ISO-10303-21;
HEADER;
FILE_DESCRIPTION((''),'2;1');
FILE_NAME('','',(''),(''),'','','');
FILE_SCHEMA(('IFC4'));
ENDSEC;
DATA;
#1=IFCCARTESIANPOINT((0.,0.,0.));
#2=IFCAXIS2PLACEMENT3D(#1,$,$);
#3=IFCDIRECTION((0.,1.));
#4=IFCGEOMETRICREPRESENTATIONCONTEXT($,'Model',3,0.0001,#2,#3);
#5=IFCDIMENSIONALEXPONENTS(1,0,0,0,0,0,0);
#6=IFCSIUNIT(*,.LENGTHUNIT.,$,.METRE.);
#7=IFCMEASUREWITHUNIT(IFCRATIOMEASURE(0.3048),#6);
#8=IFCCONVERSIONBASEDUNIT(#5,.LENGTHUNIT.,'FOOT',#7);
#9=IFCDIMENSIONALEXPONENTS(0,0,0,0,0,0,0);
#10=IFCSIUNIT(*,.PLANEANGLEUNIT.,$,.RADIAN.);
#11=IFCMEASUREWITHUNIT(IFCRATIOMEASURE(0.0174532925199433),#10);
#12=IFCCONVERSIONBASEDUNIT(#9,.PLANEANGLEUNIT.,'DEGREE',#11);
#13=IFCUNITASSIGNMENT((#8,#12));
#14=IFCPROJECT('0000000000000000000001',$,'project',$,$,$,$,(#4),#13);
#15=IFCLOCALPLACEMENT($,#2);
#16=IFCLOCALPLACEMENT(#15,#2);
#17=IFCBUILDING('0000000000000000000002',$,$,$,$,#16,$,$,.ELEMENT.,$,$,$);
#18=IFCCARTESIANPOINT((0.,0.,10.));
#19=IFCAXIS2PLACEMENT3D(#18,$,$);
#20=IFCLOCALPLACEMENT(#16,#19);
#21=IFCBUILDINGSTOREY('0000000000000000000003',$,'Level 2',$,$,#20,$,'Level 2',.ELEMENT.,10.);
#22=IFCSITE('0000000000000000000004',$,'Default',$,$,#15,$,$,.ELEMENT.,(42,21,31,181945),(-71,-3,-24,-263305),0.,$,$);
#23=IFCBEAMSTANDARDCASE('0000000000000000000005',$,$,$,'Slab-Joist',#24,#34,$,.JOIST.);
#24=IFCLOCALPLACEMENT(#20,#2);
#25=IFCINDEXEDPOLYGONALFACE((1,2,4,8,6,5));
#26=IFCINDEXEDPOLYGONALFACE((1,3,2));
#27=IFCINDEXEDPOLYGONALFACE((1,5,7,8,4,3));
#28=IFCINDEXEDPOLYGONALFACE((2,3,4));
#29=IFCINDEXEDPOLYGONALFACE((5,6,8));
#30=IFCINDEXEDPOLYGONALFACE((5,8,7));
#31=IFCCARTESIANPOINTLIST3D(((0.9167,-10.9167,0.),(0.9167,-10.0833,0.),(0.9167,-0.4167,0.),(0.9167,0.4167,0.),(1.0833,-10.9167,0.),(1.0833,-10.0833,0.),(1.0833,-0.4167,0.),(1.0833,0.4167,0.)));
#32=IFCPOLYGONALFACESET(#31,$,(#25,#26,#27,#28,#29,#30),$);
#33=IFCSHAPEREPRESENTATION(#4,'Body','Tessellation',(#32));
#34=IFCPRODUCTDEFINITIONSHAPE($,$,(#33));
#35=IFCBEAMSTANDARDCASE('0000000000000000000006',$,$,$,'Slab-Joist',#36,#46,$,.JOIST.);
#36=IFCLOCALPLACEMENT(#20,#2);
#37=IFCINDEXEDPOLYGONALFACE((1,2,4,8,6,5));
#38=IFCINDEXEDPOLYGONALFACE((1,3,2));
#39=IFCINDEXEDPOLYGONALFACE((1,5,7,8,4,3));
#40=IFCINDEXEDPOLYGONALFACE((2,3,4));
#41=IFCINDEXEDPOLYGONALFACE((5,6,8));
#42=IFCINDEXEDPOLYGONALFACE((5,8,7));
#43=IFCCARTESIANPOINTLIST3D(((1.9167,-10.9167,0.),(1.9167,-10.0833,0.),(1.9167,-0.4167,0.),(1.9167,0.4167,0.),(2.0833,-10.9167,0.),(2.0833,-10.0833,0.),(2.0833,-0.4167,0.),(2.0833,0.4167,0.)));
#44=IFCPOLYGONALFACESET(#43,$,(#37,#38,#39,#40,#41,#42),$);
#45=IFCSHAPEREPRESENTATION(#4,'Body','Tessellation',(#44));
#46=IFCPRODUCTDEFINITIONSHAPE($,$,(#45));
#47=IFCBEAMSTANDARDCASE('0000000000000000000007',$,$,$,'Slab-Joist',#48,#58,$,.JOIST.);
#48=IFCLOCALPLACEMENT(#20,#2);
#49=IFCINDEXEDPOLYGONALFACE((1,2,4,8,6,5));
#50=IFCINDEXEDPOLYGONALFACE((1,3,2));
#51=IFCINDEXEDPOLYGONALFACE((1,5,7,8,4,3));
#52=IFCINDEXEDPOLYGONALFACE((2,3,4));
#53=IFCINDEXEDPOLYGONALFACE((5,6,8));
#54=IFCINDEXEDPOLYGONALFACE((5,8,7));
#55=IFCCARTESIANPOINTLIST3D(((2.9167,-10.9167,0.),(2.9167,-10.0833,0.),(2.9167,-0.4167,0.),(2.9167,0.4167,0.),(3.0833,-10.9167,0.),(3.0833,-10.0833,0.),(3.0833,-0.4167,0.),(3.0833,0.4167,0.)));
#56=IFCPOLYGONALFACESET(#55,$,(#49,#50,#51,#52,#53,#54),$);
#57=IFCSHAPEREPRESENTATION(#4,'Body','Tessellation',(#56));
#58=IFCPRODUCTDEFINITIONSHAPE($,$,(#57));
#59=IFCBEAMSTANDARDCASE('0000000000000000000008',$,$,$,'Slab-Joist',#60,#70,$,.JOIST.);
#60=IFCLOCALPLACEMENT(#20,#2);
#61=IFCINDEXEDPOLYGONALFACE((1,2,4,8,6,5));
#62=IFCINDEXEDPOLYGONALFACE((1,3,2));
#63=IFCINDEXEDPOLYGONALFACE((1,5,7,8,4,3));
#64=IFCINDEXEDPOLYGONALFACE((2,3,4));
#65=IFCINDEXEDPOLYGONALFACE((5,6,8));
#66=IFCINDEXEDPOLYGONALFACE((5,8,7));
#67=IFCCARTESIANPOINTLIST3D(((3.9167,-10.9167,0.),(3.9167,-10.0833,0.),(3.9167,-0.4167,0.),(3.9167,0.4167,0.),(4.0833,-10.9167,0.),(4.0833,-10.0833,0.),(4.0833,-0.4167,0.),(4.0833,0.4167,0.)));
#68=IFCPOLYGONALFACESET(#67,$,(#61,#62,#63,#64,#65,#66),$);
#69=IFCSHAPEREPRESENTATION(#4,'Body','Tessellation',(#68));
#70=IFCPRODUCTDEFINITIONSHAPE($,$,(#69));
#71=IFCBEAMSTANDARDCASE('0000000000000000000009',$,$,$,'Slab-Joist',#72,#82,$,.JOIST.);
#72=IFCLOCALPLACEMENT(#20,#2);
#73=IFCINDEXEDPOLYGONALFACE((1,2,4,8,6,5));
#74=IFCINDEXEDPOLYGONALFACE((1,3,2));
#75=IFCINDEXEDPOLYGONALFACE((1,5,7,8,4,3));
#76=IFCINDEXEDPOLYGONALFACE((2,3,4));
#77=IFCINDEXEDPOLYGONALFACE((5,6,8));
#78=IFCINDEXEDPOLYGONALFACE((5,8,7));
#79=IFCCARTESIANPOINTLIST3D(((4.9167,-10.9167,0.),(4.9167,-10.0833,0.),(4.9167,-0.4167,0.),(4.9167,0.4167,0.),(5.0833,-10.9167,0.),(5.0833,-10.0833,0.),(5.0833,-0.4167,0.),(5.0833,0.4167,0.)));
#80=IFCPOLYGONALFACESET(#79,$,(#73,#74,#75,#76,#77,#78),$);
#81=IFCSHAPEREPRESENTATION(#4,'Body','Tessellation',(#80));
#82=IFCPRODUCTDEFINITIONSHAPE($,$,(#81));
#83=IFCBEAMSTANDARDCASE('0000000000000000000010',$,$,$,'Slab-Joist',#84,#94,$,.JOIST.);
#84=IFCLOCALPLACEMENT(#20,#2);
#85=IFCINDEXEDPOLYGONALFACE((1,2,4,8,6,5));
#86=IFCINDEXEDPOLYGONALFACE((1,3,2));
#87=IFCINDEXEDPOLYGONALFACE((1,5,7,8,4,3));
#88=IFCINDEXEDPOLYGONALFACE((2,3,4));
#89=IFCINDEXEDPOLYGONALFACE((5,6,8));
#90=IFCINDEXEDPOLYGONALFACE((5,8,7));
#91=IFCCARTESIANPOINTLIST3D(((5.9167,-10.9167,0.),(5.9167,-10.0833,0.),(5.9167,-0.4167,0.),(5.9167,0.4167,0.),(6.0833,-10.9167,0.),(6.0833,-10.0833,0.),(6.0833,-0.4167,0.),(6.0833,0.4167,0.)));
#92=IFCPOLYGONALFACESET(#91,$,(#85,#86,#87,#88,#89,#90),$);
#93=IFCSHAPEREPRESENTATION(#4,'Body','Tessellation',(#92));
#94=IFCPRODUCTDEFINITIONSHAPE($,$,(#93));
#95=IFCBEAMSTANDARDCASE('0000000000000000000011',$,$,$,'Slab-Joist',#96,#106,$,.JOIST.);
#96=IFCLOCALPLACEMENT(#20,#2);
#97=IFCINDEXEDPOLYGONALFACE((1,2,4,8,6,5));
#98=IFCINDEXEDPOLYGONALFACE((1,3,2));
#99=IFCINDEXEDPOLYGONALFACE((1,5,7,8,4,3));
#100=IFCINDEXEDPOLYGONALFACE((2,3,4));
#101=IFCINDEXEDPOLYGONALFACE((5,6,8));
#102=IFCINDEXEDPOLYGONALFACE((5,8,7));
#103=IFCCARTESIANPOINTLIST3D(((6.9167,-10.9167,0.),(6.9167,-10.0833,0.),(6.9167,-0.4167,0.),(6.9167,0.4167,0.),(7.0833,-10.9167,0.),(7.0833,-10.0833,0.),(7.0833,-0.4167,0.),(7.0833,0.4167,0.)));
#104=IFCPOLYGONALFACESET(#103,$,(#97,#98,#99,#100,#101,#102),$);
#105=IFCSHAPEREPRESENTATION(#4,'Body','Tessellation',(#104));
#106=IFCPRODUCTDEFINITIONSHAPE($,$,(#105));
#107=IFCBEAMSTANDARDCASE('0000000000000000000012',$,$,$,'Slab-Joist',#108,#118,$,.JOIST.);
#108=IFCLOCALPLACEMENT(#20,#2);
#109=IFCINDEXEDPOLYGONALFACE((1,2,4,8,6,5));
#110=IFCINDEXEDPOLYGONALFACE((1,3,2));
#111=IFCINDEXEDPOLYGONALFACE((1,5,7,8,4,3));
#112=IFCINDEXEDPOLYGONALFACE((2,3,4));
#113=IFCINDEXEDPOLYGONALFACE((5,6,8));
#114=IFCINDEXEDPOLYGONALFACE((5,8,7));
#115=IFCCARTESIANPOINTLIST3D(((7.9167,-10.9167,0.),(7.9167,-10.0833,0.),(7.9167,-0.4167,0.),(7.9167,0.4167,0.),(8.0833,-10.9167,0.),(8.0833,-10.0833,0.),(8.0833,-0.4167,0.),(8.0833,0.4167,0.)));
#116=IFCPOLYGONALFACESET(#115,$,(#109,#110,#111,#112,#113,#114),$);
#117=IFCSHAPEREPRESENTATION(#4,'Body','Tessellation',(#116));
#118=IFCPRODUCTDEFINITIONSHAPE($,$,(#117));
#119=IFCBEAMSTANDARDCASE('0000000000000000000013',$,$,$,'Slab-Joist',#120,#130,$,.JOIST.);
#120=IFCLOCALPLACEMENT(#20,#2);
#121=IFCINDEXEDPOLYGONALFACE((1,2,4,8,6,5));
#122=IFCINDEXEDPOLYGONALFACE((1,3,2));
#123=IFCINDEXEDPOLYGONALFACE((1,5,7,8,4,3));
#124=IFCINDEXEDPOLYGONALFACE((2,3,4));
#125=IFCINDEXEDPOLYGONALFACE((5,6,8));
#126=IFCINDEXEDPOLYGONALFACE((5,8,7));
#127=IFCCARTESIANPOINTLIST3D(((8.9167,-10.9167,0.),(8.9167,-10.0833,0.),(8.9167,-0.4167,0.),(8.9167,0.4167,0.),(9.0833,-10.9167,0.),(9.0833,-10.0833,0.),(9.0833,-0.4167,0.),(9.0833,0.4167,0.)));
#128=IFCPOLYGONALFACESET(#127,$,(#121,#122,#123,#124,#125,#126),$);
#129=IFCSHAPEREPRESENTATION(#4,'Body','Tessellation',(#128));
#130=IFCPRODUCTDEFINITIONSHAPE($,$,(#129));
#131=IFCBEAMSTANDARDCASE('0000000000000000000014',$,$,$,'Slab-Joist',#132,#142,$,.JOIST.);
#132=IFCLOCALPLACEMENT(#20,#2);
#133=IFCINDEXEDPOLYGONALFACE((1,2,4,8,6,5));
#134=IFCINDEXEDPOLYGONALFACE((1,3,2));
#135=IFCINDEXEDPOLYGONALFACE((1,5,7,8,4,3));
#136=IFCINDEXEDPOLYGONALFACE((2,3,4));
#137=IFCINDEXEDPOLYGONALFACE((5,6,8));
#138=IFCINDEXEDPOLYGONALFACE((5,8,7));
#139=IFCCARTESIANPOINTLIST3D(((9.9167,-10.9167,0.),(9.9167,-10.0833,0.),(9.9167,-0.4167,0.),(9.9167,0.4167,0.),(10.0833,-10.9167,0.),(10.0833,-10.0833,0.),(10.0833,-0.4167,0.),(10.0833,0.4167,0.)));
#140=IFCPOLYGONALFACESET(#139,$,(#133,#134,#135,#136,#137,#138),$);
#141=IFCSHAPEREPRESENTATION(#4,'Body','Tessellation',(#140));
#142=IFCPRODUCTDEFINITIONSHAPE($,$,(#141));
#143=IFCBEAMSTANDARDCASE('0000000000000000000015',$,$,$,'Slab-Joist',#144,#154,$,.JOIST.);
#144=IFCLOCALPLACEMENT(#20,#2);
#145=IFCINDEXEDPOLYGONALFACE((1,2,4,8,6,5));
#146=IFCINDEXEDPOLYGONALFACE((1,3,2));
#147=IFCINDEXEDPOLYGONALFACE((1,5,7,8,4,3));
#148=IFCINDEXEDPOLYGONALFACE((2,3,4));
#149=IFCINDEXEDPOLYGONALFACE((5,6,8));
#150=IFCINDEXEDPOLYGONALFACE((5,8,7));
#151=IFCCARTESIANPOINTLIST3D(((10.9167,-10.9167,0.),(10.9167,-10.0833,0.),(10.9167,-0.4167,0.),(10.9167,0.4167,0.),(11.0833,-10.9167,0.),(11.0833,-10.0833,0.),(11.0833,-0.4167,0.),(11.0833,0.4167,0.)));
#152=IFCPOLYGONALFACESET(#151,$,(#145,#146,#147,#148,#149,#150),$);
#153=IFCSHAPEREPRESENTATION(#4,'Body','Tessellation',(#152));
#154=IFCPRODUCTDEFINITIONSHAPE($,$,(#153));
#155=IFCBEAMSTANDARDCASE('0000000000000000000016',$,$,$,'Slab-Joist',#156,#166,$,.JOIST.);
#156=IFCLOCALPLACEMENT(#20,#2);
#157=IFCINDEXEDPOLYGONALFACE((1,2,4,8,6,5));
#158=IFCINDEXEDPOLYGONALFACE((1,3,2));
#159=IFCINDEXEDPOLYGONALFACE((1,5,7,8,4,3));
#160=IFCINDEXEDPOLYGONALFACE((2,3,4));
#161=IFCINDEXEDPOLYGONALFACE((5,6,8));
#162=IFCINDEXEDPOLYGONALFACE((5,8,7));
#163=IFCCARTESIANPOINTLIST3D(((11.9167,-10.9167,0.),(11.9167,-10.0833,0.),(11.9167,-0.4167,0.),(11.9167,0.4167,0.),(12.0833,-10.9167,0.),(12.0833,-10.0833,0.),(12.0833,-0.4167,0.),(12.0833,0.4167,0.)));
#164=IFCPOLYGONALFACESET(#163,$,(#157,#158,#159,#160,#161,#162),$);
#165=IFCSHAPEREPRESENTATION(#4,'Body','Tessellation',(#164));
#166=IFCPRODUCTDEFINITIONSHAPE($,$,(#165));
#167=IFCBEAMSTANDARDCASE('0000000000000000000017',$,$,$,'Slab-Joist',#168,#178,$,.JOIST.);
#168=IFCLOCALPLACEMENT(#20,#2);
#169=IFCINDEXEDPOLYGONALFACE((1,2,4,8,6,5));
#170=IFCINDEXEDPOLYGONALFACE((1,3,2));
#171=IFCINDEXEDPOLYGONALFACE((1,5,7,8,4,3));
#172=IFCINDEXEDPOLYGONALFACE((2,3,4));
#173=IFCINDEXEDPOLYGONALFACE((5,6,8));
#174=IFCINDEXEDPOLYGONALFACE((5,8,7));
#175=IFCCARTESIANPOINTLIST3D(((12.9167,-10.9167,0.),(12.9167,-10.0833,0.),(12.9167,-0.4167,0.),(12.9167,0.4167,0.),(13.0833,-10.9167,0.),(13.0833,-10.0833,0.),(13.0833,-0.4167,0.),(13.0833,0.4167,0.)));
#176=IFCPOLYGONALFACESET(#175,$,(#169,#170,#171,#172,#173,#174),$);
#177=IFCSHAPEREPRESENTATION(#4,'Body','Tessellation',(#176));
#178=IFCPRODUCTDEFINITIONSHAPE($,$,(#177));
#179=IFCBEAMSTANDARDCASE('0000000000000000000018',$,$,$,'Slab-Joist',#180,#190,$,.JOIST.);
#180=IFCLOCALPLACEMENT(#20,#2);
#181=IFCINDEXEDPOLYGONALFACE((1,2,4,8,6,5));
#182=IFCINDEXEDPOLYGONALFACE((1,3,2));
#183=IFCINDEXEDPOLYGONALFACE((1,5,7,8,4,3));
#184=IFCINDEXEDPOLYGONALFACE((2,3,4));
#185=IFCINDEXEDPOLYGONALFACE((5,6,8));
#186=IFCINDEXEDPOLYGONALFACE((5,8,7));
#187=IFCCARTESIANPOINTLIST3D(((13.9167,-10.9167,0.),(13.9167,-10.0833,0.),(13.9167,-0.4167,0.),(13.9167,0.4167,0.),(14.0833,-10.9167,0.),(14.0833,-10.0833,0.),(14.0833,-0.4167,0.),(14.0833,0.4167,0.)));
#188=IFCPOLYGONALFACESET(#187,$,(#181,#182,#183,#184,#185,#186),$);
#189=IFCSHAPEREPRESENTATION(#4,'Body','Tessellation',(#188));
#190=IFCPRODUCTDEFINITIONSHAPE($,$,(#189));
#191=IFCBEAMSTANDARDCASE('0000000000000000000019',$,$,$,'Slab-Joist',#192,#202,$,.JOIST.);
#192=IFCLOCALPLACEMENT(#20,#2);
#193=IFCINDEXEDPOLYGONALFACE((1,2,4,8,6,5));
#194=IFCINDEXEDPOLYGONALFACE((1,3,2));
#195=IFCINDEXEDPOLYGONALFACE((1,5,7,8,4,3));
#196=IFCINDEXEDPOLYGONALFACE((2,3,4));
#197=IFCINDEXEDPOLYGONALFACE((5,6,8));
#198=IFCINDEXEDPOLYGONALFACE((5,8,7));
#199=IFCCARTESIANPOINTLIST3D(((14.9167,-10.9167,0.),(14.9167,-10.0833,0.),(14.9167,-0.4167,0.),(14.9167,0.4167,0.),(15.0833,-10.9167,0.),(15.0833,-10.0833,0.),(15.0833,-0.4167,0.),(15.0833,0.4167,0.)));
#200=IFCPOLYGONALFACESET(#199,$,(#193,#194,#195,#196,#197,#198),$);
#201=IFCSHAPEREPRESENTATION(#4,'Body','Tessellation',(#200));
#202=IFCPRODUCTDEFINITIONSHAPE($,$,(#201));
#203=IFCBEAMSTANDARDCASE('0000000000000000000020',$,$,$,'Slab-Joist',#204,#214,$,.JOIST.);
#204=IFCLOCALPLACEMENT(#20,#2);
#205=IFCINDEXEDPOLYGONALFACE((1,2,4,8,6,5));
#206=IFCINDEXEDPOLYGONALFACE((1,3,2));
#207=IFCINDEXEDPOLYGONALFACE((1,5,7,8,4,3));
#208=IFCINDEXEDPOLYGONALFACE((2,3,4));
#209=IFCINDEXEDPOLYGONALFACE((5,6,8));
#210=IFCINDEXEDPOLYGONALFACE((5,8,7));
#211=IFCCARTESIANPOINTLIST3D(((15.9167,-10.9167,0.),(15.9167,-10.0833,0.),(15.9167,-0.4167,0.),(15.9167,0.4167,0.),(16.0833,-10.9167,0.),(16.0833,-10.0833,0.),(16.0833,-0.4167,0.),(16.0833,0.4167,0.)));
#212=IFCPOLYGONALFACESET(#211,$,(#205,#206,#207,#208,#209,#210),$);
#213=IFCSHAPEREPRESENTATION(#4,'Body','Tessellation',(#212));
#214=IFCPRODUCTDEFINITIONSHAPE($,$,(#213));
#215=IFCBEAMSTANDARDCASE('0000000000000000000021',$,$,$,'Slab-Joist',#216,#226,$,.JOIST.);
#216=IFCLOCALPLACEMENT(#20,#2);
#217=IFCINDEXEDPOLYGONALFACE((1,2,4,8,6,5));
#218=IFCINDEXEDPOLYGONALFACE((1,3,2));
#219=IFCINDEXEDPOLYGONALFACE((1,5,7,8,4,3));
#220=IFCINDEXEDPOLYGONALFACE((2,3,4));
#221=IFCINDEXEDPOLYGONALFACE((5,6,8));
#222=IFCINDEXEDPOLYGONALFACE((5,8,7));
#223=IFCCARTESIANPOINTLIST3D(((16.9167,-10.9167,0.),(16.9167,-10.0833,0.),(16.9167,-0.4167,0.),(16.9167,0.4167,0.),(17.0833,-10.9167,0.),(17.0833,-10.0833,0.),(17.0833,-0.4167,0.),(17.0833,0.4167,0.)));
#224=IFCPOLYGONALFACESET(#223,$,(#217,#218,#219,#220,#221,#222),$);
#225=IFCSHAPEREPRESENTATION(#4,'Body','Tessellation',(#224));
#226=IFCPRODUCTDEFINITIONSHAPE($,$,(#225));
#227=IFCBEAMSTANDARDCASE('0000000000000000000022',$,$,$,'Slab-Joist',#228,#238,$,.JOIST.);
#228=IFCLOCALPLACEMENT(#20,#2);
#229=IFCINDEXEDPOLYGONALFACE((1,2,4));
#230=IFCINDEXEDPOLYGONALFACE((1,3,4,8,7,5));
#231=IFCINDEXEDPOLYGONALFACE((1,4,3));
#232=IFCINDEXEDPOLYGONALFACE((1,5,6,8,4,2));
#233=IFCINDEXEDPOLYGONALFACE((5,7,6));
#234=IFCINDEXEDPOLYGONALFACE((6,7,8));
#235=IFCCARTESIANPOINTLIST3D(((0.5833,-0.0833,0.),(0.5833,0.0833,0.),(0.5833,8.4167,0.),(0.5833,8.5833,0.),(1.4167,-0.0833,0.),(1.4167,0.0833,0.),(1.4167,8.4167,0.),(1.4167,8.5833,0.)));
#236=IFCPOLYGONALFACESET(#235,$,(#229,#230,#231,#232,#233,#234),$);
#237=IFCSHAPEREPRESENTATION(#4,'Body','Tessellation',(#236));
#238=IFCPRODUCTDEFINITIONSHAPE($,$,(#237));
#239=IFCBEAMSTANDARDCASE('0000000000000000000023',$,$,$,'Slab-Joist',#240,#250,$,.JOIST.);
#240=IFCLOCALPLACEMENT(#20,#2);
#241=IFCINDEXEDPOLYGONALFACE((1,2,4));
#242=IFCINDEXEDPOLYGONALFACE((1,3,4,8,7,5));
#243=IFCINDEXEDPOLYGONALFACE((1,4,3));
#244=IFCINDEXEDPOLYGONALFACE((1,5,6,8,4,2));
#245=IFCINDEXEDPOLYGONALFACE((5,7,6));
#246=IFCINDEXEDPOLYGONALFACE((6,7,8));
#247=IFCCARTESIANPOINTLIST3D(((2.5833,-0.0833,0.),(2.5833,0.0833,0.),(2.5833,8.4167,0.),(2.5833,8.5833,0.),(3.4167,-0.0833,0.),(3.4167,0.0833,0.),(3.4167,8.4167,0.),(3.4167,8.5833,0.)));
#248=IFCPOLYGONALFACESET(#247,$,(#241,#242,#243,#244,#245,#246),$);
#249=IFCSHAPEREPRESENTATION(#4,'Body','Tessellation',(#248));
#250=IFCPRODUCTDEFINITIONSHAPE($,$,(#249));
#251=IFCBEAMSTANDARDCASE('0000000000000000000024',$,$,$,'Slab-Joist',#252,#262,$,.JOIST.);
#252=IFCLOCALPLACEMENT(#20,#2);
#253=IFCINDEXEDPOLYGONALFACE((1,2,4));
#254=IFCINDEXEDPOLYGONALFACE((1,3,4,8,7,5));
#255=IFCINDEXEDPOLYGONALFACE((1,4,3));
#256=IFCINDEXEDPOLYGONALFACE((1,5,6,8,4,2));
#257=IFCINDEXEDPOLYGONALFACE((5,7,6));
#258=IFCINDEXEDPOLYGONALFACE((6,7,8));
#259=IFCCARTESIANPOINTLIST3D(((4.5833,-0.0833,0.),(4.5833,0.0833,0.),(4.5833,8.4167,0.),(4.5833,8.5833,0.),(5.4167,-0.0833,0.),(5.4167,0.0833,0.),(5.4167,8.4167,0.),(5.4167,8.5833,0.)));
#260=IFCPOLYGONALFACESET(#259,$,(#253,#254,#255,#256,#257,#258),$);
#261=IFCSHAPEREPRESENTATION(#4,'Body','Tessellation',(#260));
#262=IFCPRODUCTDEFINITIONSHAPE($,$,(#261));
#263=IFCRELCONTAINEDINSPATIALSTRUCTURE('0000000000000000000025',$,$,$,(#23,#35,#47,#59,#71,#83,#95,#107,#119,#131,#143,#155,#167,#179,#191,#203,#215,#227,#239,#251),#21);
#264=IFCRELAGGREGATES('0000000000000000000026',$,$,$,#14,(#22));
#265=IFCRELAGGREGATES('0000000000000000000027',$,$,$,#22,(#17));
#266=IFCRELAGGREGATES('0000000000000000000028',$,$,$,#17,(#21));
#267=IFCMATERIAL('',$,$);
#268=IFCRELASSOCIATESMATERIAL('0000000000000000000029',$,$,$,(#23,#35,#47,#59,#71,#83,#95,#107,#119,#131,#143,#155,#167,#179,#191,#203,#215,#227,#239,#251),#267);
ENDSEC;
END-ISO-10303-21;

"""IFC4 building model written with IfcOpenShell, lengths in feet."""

from ifc_helpers import new_model, entity, si_unit, converted_unit, direction, frame, origin, place, context, project, spatial, rectangle, extrude, material, element, save


model = new_model("IFC4")

# Units and contexts
model_context = context("Model", 3, precision=0.0001, world=origin(), true_north=direction((0.0, 1.0)))
ifc_project = project(units=[converted_unit("LENGTHUNIT", "FOOT", entity("IfcRatioMeasure", 0.3048), si_unit("LENGTHUNIT", "METRE"), dimensions=[1, 0, 0, 0, 0, 0, 0]), converted_unit("PLANEANGLEUNIT", "DEGREE", entity("IfcRatioMeasure", 0.0174532925199433), si_unit("PLANEANGLEUNIT", "RADIAN"), dimensions=[0, 0, 0, 0, 0, 0, 0])], contexts=[model_context])

# Site, building, storey
site_placement = place(None, origin())
site = spatial("IfcSite", under=ifc_project, at=site_placement, Name="Default", CompositionType="ELEMENT", RefLatitude=(42, 21, 31, 181945), RefLongitude=(-71, -3, -24, -263305), RefElevation=0.0)
building_placement = place(site_placement, origin())
building = spatial("IfcBuilding", under=site, at=building_placement, CompositionType="ELEMENT")
storey_placement = place(building_placement, frame((0.0, 0.0, 10.0)))
storey = spatial("IfcBuildingStorey", under=building, at=storey_placement, Name="Level 2", LongName="Level 2", CompositionType="ELEMENT", Elevation=10.0)

# Beams
ifc_material_1 = material(Name="")
for number, where, z_axis, x_axis in (
    (1, (1.0, 0.0, 0.0), (0.0, 0.0, 1.0), (1.0, 0.0, 0.0)),
    (2, (2.0, 0.0, 0.0), (0.0, 0.0, 1.0), (1.0, 0.0, 0.0)),
    (3, (3.0, 0.0, 0.0), (0.0, 0.0, 1.0), (1.0, 0.0, 0.0)),
    (4, (4.0, 0.0, 0.0), (0.0, 0.0, 1.0), (1.0, 0.0, 0.0)),
    (5, (5.0, 0.0, 0.0), (0.0, 0.0, 1.0), (1.0, 0.0, 0.0)),
    (6, (6.0, 0.0, 0.0), (0.0, 0.0, 1.0), (1.0, 0.0, 0.0)),
    (7, (7.0, 0.0, 0.0), (0.0, 0.0, 1.0), (1.0, 0.0, 0.0)),
    (8, (8.0, 0.0, 0.0), (0.0, 0.0, 1.0), (1.0, 0.0, 0.0)),
    (9, (9.0, 0.0, 0.0), (0.0, 0.0, 1.0), (1.0, 0.0, 0.0)),
    (10, (10.0, 0.0, 0.0), (0.0, 0.0, 1.0), (1.0, 0.0, 0.0)),
    (11, (11.0, 0.0, 0.0), (0.0, 0.0, 1.0), (1.0, 0.0, 0.0)),
    (12, (12.0, 0.0, 0.0), (0.0, 0.0, 1.0), (1.0, 0.0, 0.0)),
    (13, (13.0, 0.0, 0.0), (0.0, 0.0, 1.0), (1.0, 0.0, 0.0)),
    (14, (14.0, 0.0, 0.0), (0.0, 0.0, 1.0), (1.0, 0.0, 0.0)),
    (15, (15.0, 0.0, 0.0), (0.0, 0.0, 1.0), (1.0, 0.0, 0.0)),
    (16, (16.0, 0.0, 0.0), (0.0, 0.0, 1.0), (1.0, 0.0, 0.0)),
    (17, (17.0, 0.0, 0.0), (0.0, 0.0, 1.0), (1.0, 0.0, 0.0)),
):
    element("IfcBeamStandardCase", number, at=place(storey_placement, frame(where, z_axis=z_axis, x_axis=x_axis)), inside=storey, material=ifc_material_1, ObjectType="Slab-Joist", PredefinedType="JOIST", context=model_context, shape_type="SweptSolid", body=[
        extrude(rectangle(XDim=0.1667, YDim=0.8333), frame((0.0, 0.0, 0.0), z_axis=(0.0, 0.0, 1.0), x_axis=(-1.0, 0.0, 0.0)), (0.0, 1.0, 0.0), 10.5),
    ])
for number, where, z_axis, x_axis in (
    (18, (1.0, 0.0, 0.0), (0.0, 0.0, 1.0), (1.0, 0.0, 0.0)),
    (19, (3.0, 0.0, 0.0), (0.0, 0.0, 1.0), (1.0, 0.0, 0.0)),
    (20, (5.0, 0.0, 0.0), (0.0, 0.0, 1.0), (1.0, 0.0, 0.0)),
):
    element("IfcBeamStandardCase", number, at=place(storey_placement, frame(where, z_axis=z_axis, x_axis=x_axis)), inside=storey, material=ifc_material_1, ObjectType="Slab-Joist", PredefinedType="JOIST", context=model_context, shape_type="SweptSolid", body=[
        extrude(rectangle(XDim=0.1667, YDim=0.8333), frame((0.0, 0.0, 0.0), z_axis=(0.0, 0.0, 1.0), x_axis=(0.0, 1.0, 0.0)), (1.0, 0.0, 0.0), 8.5),
    ])

save(model, "model.ifc")
